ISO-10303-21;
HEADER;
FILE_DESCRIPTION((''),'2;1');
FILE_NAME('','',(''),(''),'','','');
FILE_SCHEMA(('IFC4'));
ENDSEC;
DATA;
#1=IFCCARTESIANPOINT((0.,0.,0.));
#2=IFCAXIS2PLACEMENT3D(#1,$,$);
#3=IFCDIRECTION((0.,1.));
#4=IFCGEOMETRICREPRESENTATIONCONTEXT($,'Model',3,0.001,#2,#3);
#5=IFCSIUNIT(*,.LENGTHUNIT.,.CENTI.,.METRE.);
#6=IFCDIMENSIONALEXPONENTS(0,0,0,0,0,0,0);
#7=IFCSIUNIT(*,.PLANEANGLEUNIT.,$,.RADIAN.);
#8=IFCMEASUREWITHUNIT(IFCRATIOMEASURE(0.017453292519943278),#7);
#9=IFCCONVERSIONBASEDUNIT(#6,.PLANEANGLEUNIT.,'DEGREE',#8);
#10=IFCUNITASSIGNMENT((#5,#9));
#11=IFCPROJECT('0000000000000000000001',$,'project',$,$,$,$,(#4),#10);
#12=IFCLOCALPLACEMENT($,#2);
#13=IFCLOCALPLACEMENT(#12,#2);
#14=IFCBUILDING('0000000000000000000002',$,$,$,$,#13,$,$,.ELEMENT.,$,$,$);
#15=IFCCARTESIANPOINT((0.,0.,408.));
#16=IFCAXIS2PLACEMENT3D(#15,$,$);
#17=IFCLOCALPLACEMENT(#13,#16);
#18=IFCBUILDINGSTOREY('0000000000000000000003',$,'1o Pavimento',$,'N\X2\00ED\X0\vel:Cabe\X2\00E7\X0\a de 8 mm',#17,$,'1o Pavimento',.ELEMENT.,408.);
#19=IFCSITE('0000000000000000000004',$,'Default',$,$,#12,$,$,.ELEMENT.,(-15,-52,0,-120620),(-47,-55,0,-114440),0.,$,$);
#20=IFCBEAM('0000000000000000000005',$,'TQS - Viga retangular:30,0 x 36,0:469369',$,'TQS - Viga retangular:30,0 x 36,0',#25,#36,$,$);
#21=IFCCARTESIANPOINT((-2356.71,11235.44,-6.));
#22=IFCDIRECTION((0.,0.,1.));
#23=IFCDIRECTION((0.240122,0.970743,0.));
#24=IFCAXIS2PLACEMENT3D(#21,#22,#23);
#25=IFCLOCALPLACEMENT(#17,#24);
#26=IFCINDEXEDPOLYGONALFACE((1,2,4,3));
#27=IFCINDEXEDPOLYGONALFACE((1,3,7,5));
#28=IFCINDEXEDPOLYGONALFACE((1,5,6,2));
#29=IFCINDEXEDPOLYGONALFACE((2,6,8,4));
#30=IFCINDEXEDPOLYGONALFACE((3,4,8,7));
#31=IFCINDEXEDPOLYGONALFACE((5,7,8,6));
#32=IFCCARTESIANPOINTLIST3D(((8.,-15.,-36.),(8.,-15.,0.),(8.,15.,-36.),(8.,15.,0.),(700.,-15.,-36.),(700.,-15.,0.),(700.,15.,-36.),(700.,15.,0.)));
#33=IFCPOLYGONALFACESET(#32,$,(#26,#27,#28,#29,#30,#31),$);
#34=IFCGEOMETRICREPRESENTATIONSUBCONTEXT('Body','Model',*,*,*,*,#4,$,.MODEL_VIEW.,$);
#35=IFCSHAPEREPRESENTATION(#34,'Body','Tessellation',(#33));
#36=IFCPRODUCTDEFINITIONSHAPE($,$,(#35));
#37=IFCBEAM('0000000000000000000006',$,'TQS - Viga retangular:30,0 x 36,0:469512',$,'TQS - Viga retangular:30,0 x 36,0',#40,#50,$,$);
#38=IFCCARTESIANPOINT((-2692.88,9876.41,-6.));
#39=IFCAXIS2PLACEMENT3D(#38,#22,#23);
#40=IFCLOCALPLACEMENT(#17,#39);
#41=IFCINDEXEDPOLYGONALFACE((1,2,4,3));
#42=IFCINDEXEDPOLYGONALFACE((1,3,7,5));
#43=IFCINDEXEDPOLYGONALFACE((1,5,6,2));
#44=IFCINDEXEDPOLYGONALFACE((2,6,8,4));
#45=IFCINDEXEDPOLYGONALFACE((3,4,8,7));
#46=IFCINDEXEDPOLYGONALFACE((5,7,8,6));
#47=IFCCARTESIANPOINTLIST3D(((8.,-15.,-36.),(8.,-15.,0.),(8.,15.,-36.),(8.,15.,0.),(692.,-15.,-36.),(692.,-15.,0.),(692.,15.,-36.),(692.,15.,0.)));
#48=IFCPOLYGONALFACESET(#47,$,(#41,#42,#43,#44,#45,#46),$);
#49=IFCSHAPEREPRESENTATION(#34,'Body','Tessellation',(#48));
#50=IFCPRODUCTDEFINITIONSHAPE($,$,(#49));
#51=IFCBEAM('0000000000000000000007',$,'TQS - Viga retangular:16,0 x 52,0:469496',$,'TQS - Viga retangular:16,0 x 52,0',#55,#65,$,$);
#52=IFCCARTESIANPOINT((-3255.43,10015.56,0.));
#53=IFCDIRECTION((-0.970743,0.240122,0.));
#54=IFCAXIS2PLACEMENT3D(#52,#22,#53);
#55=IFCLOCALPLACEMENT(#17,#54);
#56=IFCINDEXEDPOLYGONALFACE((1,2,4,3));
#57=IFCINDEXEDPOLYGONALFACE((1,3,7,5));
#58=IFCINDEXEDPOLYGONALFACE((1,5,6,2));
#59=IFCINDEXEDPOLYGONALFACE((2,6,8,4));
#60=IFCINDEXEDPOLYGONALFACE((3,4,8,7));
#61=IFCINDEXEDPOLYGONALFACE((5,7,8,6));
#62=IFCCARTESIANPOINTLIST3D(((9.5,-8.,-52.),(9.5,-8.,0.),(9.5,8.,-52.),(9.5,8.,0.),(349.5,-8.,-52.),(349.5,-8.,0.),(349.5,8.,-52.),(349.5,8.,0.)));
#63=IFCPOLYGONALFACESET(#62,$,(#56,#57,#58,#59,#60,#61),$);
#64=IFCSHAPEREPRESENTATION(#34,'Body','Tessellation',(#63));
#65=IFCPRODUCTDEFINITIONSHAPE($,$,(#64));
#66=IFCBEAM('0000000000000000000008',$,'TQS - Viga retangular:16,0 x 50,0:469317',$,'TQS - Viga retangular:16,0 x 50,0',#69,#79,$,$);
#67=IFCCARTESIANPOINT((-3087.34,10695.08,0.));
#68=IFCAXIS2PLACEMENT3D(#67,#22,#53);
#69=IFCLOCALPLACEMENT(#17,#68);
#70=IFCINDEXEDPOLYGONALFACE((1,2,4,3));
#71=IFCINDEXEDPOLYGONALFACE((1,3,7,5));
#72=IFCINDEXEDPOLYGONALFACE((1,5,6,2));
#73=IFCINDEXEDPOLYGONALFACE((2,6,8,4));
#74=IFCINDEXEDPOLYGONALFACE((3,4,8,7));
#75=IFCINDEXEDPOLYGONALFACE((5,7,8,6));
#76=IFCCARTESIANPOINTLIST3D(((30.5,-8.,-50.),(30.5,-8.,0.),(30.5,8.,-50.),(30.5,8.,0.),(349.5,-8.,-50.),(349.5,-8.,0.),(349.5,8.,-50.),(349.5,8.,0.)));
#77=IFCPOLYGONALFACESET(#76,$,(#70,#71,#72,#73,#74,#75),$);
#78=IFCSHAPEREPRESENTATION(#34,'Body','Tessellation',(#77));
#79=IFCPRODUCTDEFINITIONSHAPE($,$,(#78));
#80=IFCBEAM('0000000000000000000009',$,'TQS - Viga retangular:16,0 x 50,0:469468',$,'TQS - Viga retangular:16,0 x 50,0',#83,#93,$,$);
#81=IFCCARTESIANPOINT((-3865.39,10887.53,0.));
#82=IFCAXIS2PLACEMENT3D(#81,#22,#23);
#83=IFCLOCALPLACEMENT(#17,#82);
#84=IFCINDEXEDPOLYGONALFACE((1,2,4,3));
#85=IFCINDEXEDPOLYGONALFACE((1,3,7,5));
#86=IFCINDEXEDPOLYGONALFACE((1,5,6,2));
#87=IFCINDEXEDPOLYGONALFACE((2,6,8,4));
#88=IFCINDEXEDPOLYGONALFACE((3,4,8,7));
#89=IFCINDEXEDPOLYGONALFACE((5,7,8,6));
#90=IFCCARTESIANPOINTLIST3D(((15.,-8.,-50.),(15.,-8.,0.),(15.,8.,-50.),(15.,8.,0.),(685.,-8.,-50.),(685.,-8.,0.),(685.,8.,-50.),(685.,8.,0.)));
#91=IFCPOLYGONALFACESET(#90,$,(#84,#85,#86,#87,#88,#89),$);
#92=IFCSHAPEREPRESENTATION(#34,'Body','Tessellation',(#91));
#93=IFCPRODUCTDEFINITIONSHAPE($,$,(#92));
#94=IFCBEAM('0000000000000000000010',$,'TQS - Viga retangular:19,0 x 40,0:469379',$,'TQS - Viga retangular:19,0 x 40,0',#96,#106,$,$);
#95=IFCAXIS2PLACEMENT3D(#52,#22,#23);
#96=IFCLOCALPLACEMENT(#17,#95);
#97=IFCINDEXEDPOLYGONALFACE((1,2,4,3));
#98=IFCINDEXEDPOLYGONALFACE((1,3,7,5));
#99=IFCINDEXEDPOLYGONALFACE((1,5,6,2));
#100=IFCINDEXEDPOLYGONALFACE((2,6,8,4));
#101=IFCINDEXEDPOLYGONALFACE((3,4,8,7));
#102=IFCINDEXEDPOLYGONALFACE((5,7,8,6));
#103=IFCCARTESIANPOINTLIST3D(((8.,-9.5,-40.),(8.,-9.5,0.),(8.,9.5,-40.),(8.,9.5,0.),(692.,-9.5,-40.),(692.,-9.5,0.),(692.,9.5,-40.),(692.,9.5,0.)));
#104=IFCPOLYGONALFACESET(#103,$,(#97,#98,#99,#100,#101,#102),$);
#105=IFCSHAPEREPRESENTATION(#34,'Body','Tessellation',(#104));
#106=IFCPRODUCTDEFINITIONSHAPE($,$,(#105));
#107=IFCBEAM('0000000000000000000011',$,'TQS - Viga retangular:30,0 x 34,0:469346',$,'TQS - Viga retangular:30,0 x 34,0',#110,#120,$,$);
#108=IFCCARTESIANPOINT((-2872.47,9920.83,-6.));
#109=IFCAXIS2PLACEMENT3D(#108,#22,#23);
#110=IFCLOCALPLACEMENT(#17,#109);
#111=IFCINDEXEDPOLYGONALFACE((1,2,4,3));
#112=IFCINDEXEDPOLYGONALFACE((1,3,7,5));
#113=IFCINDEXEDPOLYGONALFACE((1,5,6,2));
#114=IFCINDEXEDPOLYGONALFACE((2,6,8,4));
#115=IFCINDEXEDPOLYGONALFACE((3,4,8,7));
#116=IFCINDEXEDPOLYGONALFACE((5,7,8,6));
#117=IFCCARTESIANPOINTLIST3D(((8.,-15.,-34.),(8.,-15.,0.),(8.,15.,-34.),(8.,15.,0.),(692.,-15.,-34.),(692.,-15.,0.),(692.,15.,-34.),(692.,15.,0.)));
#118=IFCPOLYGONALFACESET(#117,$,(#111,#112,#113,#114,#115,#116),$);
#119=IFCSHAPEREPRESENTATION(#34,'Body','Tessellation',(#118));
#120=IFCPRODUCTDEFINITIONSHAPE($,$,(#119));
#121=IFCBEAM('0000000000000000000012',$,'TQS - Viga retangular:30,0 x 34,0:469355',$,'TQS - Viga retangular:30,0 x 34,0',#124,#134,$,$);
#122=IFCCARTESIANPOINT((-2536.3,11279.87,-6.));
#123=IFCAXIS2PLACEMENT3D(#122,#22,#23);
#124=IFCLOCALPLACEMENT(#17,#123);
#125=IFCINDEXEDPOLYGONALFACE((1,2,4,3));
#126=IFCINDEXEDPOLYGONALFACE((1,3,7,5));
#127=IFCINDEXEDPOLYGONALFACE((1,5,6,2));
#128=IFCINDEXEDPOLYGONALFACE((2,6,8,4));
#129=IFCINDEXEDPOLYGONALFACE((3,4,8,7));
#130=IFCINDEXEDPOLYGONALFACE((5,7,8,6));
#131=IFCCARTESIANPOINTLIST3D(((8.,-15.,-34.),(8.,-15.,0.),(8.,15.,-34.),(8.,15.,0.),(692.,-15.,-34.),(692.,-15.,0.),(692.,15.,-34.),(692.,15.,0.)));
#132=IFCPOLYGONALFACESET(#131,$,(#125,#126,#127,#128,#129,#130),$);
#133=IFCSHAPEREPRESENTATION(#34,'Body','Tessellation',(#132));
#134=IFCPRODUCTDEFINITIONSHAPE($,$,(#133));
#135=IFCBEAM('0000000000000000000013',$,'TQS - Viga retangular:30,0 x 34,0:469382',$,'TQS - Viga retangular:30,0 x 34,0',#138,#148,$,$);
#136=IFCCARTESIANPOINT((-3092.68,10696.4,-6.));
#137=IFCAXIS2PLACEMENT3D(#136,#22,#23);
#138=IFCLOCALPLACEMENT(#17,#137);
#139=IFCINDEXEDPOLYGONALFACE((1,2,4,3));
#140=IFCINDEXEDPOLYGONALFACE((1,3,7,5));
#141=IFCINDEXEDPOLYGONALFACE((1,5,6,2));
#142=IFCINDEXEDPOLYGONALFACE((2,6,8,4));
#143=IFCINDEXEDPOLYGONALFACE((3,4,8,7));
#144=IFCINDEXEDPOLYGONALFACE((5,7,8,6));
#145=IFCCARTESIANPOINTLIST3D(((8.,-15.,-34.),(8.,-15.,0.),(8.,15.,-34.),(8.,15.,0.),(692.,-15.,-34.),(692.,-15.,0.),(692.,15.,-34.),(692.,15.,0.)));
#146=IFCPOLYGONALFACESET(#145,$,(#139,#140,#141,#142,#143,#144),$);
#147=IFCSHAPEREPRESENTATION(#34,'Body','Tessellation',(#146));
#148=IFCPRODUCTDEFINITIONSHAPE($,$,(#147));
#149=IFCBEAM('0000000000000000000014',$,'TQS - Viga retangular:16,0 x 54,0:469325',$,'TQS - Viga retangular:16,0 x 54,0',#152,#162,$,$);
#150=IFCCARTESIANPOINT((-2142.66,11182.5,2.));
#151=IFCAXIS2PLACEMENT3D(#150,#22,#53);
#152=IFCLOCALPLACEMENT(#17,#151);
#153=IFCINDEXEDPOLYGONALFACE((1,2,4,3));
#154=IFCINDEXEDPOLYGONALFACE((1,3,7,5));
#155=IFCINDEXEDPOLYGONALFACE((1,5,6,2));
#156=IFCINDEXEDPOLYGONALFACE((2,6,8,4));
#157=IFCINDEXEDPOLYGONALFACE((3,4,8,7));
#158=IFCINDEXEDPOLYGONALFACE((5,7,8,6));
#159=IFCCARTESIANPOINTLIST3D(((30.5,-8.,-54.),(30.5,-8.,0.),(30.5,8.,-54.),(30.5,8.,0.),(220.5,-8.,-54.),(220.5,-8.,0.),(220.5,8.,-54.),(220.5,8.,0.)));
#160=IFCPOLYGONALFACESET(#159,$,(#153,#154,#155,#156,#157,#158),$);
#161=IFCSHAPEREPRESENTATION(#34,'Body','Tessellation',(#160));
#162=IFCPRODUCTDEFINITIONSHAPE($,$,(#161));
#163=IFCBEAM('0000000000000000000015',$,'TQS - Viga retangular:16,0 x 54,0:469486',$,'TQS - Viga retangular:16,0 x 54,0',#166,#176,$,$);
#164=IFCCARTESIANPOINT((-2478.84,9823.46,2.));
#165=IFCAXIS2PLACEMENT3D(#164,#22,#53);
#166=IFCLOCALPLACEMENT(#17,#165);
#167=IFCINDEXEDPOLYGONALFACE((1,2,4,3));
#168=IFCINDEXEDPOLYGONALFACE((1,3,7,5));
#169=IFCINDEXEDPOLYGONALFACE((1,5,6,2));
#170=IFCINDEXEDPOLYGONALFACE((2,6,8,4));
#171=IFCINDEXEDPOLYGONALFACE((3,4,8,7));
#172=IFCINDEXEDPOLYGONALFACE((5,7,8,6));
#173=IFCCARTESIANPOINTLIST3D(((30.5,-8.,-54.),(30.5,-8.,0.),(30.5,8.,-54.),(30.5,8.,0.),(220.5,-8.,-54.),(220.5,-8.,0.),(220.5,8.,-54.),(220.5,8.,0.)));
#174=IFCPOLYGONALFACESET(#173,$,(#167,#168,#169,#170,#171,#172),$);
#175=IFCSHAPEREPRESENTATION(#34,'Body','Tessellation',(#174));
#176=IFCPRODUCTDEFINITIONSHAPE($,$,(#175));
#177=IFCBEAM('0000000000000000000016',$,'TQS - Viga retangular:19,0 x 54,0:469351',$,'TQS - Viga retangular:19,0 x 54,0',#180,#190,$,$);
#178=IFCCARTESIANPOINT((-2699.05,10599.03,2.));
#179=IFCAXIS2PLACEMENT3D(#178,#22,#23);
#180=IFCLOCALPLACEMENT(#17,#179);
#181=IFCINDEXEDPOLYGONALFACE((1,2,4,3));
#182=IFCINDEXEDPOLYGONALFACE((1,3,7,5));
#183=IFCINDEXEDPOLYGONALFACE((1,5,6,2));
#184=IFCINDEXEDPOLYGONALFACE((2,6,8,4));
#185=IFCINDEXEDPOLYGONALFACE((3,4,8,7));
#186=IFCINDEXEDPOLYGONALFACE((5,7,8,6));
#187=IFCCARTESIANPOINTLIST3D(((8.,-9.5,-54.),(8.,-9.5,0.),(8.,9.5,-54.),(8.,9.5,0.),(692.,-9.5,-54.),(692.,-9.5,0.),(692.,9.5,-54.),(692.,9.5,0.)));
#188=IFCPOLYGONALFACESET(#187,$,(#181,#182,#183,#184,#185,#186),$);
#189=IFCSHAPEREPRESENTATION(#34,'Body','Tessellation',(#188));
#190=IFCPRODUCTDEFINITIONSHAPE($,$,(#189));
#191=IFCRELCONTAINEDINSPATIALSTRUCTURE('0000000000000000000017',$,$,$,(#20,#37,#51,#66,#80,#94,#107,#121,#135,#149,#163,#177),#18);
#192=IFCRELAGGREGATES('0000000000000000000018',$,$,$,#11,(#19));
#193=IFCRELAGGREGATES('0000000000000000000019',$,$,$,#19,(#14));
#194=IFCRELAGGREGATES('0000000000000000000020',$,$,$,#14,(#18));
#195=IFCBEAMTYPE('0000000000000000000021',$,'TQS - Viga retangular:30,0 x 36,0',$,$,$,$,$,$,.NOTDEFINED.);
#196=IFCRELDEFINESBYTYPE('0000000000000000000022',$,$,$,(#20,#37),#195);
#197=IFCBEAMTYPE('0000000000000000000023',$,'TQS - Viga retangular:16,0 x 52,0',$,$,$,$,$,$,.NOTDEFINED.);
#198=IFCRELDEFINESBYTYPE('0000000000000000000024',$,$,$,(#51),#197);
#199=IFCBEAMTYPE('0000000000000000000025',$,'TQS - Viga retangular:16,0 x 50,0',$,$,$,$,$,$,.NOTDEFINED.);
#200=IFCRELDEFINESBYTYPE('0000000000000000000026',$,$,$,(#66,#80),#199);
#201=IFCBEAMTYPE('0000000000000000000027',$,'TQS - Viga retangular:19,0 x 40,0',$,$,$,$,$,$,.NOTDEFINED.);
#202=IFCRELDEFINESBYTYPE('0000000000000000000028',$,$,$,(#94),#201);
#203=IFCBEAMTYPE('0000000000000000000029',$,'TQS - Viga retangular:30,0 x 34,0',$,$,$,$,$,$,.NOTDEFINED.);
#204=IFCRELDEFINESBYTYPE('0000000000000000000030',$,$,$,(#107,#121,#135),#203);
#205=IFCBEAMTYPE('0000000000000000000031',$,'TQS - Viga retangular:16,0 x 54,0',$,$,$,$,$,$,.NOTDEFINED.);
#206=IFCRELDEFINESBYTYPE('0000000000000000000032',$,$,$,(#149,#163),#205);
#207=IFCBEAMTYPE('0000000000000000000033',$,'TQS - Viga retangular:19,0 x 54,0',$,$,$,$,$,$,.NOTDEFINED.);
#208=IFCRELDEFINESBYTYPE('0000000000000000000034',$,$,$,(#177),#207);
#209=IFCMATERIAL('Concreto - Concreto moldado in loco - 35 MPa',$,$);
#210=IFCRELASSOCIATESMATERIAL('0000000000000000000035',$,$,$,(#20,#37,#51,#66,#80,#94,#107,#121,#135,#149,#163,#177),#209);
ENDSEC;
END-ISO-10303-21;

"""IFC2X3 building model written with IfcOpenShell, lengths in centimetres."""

from ifc_helpers import new_model, entity, si_unit, converted_unit, direction, frame, frame_2d, origin, origin_2d_with_axis, place, context, subcontext, project, spatial, rectangle, extrude, material, type_object, element, save


model = new_model("IFC2X3")

# Units and contexts
model_context = context("Model", 3, precision=0.001, world=origin(), true_north=direction((0.0, 1.0)))
body_context = subcontext(model_context, "Body", "Model", "MODEL_VIEW")
ifc_project = project(units=[si_unit("LENGTHUNIT", "METRE", prefix="CENTI"), converted_unit("PLANEANGLEUNIT", "DEGREE", entity("IfcRatioMeasure", 0.017453292519943278), si_unit("PLANEANGLEUNIT", "RADIAN"), dimensions=[0, 0, 0, 0, 0, 0, 0])], contexts=[model_context])

# Site, building, storey
site_placement = place(None, origin())
site = spatial("IfcSite", under=ifc_project, at=site_placement, Name="Default", CompositionType="ELEMENT", RefLatitude=(-15, -52, 0, -120620), RefLongitude=(-47, -55, 0, -114440), RefElevation=0.0)
building_placement = place(site_placement, origin())
building = spatial("IfcBuilding", under=site, at=building_placement, CompositionType="ELEMENT")
storey_placement = place(building_placement, frame((0.0, 0.0, 408.0)))
storey = spatial("IfcBuildingStorey", under=building, at=storey_placement, Name="1o Pavimento", ObjectType="Nível:Cabeça de 8 mm", LongName="1o Pavimento", CompositionType="ELEMENT", Elevation=408.0)

# Beams
ifc_material_1 = material(Name="Concreto - Concreto moldado in loco - 35 MPa")
beam_type_1 = type_object("IfcBeamType", Name="TQS - Viga retangular:30,0 x 36,0", PredefinedType="NOTDEFINED")
beam_1_placement = place(storey_placement, frame((-2356.71, 11235.44, -6.0), z_axis=(0.0, 0.0, 1.0), x_axis=(0.240122, 0.970743, 0.0)))
element("IfcBeam", 1, at=beam_1_placement, inside=storey, type_object=beam_type_1, material=ifc_material_1, Name="TQS - Viga retangular:30,0 x 36,0:469369", ObjectType="TQS - Viga retangular:30,0 x 36,0", context=body_context, shape_type="SweptSolid", body=[
    extrude(rectangle(XDim=36.0, YDim=30.0, at=frame_2d((0.0, 0.0), x_axis=(1.0, 0.0))), frame((8.0, 0.0, -18.0), z_axis=(1.0, 0.0, 0.0), x_axis=(0.0, 0.0, -1.0)), (0.0, 0.0, 1.0), 692.0),
])
beam_2_placement = place(storey_placement, frame((-2692.88, 9876.41, -6.0), z_axis=(0.0, 0.0, 1.0), x_axis=(0.240122, 0.970743, 0.0)))
element("IfcBeam", 2, at=beam_2_placement, inside=storey, type_object=beam_type_1, material=ifc_material_1, Name="TQS - Viga retangular:30,0 x 36,0:469512", ObjectType="TQS - Viga retangular:30,0 x 36,0", context=body_context, shape_type="SweptSolid", body=[
    extrude(rectangle(XDim=36.0, YDim=30.0, at=frame_2d((0.0, 0.0), x_axis=(1.0, 0.0))), frame((8.0, 0.0, -18.0), z_axis=(1.0, 0.0, 0.0), x_axis=(0.0, 0.0, -1.0)), (0.0, 0.0, 1.0), 684.0),
])
beam_type_2 = type_object("IfcBeamType", Name="TQS - Viga retangular:16,0 x 52,0", PredefinedType="NOTDEFINED")
beam_3_placement = place(storey_placement, frame((-3255.43, 10015.56, 0.0), z_axis=(0.0, 0.0, 1.0), x_axis=(-0.970743, 0.240122, 0.0)))
element("IfcBeam", 3, at=beam_3_placement, inside=storey, type_object=beam_type_2, material=ifc_material_1, Name="TQS - Viga retangular:16,0 x 52,0:469496", ObjectType="TQS - Viga retangular:16,0 x 52,0", context=body_context, shape_type="SweptSolid", body=[
    extrude(rectangle(XDim=52.0, YDim=16.0, at=frame_2d((0.0, 0.0), x_axis=(1.0, 0.0))), frame((9.5, 0.0, -26.0), z_axis=(1.0, 0.0, 0.0), x_axis=(0.0, 0.0, -1.0)), (0.0, 0.0, 1.0), 340.0),
])
beam_type_3 = type_object("IfcBeamType", Name="TQS - Viga retangular:16,0 x 50,0", PredefinedType="NOTDEFINED")
beam_4_placement = place(storey_placement, frame((-3087.34, 10695.08, 0.0), z_axis=(0.0, 0.0, 1.0), x_axis=(-0.970743, 0.240122, 0.0)))
element("IfcBeam", 4, at=beam_4_placement, inside=storey, type_object=beam_type_3, material=ifc_material_1, Name="TQS - Viga retangular:16,0 x 50,0:469317", ObjectType="TQS - Viga retangular:16,0 x 50,0", context=body_context, shape_type="SweptSolid", body=[
    extrude(rectangle(XDim=50.0, YDim=16.0, at=frame_2d((0.0, 0.0), x_axis=(1.0, 0.0))), frame((30.5, 0.0, -25.0), z_axis=(1.0, 0.0, 0.0), x_axis=(0.0, 0.0, -1.0)), (0.0, 0.0, 1.0), 319.0),
])
beam_5_placement = place(storey_placement, frame((-3865.39, 10887.53, 0.0), z_axis=(0.0, 0.0, 1.0), x_axis=(0.240122, 0.970743, 0.0)))
element("IfcBeam", 5, at=beam_5_placement, inside=storey, type_object=beam_type_3, material=ifc_material_1, Name="TQS - Viga retangular:16,0 x 50,0:469468", ObjectType="TQS - Viga retangular:16,0 x 50,0", context=body_context, shape_type="SweptSolid", body=[
    extrude(rectangle(XDim=50.0, YDim=16.0, at=frame_2d((0.0, 0.0), x_axis=(1.0, 0.0))), frame((15.0, 0.0, -25.0), z_axis=(1.0, 0.0, 0.0), x_axis=(0.0, 0.0, -1.0)), (0.0, 0.0, 1.0), 670.0),
])
beam_type_4 = type_object("IfcBeamType", Name="TQS - Viga retangular:19,0 x 40,0", PredefinedType="NOTDEFINED")
beam_6_placement = place(storey_placement, frame((-3255.43, 10015.56, 0.0), z_axis=(0.0, 0.0, 1.0), x_axis=(0.240122, 0.970743, 0.0)))
element("IfcBeam", 6, at=beam_6_placement, inside=storey, type_object=beam_type_4, material=ifc_material_1, Name="TQS - Viga retangular:19,0 x 40,0:469379", ObjectType="TQS - Viga retangular:19,0 x 40,0", context=body_context, shape_type="SweptSolid", body=[
    extrude(rectangle(XDim=40.0, YDim=19.0, at=frame_2d((0.0, 0.0), x_axis=(1.0, 0.0))), frame((8.0, 0.0, -20.0), z_axis=(1.0, 0.0, 0.0), x_axis=(0.0, 0.0, -1.0)), (0.0, 0.0, 1.0), 684.0),
])
beam_type_5 = type_object("IfcBeamType", Name="TQS - Viga retangular:30,0 x 34,0", PredefinedType="NOTDEFINED")
beam_7_placement = place(storey_placement, frame((-2872.47, 9920.83, -6.0), z_axis=(0.0, 0.0, 1.0), x_axis=(0.240122, 0.970743, 0.0)))
element("IfcBeam", 7, at=beam_7_placement, inside=storey, type_object=beam_type_5, material=ifc_material_1, Name="TQS - Viga retangular:30,0 x 34,0:469346", ObjectType="TQS - Viga retangular:30,0 x 34,0", context=body_context, shape_type="SweptSolid", body=[
    extrude(rectangle(XDim=34.0, YDim=30.0, at=origin_2d_with_axis()), frame((8.0, 0.0, -17.0), z_axis=(1.0, 0.0, 0.0), x_axis=(0.0, 0.0, -1.0)), (0.0, 0.0, 1.0), 684.0),
])
beam_8_placement = place(storey_placement, frame((-2536.3, 11279.87, -6.0), z_axis=(0.0, 0.0, 1.0), x_axis=(0.240122, 0.970743, 0.0)))
element("IfcBeam", 8, at=beam_8_placement, inside=storey, type_object=beam_type_5, material=ifc_material_1, Name="TQS - Viga retangular:30,0 x 34,0:469355", ObjectType="TQS - Viga retangular:30,0 x 34,0", context=body_context, shape_type="SweptSolid", body=[
    extrude(rectangle(XDim=34.0, YDim=30.0, at=origin_2d_with_axis()), frame((8.0, 0.0, -17.0), z_axis=(1.0, 0.0, 0.0), x_axis=(0.0, 0.0, -1.0)), (0.0, 0.0, 1.0), 684.0),
])
beam_9_placement = place(storey_placement, frame((-3092.68, 10696.4, -6.0), z_axis=(0.0, 0.0, 1.0), x_axis=(0.240122, 0.970743, 0.0)))
element("IfcBeam", 9, at=beam_9_placement, inside=storey, type_object=beam_type_5, material=ifc_material_1, Name="TQS - Viga retangular:30,0 x 34,0:469382", ObjectType="TQS - Viga retangular:30,0 x 34,0", context=body_context, shape_type="SweptSolid", body=[
    extrude(rectangle(XDim=34.0, YDim=30.0, at=frame_2d((0.0, 0.0), x_axis=(1.0, 0.0))), frame((8.0, 0.0, -17.0), z_axis=(1.0, 0.0, 0.0), x_axis=(0.0, 0.0, -1.0)), (0.0, 0.0, 1.0), 684.0),
])
beam_type_6 = type_object("IfcBeamType", Name="TQS - Viga retangular:16,0 x 54,0", PredefinedType="NOTDEFINED")
beam_10_placement = place(storey_placement, frame((-2142.66, 11182.5, 2.0), z_axis=(0.0, 0.0, 1.0), x_axis=(-0.970743, 0.240122, 0.0)))
element("IfcBeam", 10, at=beam_10_placement, inside=storey, type_object=beam_type_6, material=ifc_material_1, Name="TQS - Viga retangular:16,0 x 54,0:469325", ObjectType="TQS - Viga retangular:16,0 x 54,0", context=body_context, shape_type="SweptSolid", body=[
    extrude(rectangle(XDim=54.0, YDim=16.0, at=frame_2d((0.0, 0.0), x_axis=(1.0, 0.0))), frame((30.5, 0.0, -27.0), z_axis=(1.0, 0.0, 0.0), x_axis=(0.0, 0.0, -1.0)), (0.0, 0.0, 1.0), 190.0),
])
beam_11_placement = place(storey_placement, frame((-2478.84, 9823.46, 2.0), z_axis=(0.0, 0.0, 1.0), x_axis=(-0.970743, 0.240122, 0.0)))
element("IfcBeam", 11, at=beam_11_placement, inside=storey, type_object=beam_type_6, material=ifc_material_1, Name="TQS - Viga retangular:16,0 x 54,0:469486", ObjectType="TQS - Viga retangular:16,0 x 54,0", context=body_context, shape_type="SweptSolid", body=[
    extrude(rectangle(XDim=54.0, YDim=16.0, at=frame_2d((0.0, 0.0), x_axis=(1.0, 0.0))), frame((30.5, 0.0, -27.0), z_axis=(1.0, 0.0, 0.0), x_axis=(0.0, 0.0, -1.0)), (0.0, 0.0, 1.0), 190.0),
])
beam_type_7 = type_object("IfcBeamType", Name="TQS - Viga retangular:19,0 x 54,0", PredefinedType="NOTDEFINED")
beam_12_placement = place(storey_placement, frame((-2699.05, 10599.03, 2.0), z_axis=(0.0, 0.0, 1.0), x_axis=(0.240122, 0.970743, 0.0)))
element("IfcBeam", 12, at=beam_12_placement, inside=storey, type_object=beam_type_7, material=ifc_material_1, Name="TQS - Viga retangular:19,0 x 54,0:469351", ObjectType="TQS - Viga retangular:19,0 x 54,0", context=body_context, shape_type="SweptSolid", body=[
    extrude(rectangle(XDim=54.0, YDim=19.0, at=frame_2d((0.0, 0.0), x_axis=(1.0, 0.0))), frame((8.0, 0.0, -27.0), z_axis=(1.0, 0.0, 0.0), x_axis=(0.0, 0.0, -1.0)), (0.0, 0.0, 1.0), 684.0),
])

save(model, "model.ifc")
